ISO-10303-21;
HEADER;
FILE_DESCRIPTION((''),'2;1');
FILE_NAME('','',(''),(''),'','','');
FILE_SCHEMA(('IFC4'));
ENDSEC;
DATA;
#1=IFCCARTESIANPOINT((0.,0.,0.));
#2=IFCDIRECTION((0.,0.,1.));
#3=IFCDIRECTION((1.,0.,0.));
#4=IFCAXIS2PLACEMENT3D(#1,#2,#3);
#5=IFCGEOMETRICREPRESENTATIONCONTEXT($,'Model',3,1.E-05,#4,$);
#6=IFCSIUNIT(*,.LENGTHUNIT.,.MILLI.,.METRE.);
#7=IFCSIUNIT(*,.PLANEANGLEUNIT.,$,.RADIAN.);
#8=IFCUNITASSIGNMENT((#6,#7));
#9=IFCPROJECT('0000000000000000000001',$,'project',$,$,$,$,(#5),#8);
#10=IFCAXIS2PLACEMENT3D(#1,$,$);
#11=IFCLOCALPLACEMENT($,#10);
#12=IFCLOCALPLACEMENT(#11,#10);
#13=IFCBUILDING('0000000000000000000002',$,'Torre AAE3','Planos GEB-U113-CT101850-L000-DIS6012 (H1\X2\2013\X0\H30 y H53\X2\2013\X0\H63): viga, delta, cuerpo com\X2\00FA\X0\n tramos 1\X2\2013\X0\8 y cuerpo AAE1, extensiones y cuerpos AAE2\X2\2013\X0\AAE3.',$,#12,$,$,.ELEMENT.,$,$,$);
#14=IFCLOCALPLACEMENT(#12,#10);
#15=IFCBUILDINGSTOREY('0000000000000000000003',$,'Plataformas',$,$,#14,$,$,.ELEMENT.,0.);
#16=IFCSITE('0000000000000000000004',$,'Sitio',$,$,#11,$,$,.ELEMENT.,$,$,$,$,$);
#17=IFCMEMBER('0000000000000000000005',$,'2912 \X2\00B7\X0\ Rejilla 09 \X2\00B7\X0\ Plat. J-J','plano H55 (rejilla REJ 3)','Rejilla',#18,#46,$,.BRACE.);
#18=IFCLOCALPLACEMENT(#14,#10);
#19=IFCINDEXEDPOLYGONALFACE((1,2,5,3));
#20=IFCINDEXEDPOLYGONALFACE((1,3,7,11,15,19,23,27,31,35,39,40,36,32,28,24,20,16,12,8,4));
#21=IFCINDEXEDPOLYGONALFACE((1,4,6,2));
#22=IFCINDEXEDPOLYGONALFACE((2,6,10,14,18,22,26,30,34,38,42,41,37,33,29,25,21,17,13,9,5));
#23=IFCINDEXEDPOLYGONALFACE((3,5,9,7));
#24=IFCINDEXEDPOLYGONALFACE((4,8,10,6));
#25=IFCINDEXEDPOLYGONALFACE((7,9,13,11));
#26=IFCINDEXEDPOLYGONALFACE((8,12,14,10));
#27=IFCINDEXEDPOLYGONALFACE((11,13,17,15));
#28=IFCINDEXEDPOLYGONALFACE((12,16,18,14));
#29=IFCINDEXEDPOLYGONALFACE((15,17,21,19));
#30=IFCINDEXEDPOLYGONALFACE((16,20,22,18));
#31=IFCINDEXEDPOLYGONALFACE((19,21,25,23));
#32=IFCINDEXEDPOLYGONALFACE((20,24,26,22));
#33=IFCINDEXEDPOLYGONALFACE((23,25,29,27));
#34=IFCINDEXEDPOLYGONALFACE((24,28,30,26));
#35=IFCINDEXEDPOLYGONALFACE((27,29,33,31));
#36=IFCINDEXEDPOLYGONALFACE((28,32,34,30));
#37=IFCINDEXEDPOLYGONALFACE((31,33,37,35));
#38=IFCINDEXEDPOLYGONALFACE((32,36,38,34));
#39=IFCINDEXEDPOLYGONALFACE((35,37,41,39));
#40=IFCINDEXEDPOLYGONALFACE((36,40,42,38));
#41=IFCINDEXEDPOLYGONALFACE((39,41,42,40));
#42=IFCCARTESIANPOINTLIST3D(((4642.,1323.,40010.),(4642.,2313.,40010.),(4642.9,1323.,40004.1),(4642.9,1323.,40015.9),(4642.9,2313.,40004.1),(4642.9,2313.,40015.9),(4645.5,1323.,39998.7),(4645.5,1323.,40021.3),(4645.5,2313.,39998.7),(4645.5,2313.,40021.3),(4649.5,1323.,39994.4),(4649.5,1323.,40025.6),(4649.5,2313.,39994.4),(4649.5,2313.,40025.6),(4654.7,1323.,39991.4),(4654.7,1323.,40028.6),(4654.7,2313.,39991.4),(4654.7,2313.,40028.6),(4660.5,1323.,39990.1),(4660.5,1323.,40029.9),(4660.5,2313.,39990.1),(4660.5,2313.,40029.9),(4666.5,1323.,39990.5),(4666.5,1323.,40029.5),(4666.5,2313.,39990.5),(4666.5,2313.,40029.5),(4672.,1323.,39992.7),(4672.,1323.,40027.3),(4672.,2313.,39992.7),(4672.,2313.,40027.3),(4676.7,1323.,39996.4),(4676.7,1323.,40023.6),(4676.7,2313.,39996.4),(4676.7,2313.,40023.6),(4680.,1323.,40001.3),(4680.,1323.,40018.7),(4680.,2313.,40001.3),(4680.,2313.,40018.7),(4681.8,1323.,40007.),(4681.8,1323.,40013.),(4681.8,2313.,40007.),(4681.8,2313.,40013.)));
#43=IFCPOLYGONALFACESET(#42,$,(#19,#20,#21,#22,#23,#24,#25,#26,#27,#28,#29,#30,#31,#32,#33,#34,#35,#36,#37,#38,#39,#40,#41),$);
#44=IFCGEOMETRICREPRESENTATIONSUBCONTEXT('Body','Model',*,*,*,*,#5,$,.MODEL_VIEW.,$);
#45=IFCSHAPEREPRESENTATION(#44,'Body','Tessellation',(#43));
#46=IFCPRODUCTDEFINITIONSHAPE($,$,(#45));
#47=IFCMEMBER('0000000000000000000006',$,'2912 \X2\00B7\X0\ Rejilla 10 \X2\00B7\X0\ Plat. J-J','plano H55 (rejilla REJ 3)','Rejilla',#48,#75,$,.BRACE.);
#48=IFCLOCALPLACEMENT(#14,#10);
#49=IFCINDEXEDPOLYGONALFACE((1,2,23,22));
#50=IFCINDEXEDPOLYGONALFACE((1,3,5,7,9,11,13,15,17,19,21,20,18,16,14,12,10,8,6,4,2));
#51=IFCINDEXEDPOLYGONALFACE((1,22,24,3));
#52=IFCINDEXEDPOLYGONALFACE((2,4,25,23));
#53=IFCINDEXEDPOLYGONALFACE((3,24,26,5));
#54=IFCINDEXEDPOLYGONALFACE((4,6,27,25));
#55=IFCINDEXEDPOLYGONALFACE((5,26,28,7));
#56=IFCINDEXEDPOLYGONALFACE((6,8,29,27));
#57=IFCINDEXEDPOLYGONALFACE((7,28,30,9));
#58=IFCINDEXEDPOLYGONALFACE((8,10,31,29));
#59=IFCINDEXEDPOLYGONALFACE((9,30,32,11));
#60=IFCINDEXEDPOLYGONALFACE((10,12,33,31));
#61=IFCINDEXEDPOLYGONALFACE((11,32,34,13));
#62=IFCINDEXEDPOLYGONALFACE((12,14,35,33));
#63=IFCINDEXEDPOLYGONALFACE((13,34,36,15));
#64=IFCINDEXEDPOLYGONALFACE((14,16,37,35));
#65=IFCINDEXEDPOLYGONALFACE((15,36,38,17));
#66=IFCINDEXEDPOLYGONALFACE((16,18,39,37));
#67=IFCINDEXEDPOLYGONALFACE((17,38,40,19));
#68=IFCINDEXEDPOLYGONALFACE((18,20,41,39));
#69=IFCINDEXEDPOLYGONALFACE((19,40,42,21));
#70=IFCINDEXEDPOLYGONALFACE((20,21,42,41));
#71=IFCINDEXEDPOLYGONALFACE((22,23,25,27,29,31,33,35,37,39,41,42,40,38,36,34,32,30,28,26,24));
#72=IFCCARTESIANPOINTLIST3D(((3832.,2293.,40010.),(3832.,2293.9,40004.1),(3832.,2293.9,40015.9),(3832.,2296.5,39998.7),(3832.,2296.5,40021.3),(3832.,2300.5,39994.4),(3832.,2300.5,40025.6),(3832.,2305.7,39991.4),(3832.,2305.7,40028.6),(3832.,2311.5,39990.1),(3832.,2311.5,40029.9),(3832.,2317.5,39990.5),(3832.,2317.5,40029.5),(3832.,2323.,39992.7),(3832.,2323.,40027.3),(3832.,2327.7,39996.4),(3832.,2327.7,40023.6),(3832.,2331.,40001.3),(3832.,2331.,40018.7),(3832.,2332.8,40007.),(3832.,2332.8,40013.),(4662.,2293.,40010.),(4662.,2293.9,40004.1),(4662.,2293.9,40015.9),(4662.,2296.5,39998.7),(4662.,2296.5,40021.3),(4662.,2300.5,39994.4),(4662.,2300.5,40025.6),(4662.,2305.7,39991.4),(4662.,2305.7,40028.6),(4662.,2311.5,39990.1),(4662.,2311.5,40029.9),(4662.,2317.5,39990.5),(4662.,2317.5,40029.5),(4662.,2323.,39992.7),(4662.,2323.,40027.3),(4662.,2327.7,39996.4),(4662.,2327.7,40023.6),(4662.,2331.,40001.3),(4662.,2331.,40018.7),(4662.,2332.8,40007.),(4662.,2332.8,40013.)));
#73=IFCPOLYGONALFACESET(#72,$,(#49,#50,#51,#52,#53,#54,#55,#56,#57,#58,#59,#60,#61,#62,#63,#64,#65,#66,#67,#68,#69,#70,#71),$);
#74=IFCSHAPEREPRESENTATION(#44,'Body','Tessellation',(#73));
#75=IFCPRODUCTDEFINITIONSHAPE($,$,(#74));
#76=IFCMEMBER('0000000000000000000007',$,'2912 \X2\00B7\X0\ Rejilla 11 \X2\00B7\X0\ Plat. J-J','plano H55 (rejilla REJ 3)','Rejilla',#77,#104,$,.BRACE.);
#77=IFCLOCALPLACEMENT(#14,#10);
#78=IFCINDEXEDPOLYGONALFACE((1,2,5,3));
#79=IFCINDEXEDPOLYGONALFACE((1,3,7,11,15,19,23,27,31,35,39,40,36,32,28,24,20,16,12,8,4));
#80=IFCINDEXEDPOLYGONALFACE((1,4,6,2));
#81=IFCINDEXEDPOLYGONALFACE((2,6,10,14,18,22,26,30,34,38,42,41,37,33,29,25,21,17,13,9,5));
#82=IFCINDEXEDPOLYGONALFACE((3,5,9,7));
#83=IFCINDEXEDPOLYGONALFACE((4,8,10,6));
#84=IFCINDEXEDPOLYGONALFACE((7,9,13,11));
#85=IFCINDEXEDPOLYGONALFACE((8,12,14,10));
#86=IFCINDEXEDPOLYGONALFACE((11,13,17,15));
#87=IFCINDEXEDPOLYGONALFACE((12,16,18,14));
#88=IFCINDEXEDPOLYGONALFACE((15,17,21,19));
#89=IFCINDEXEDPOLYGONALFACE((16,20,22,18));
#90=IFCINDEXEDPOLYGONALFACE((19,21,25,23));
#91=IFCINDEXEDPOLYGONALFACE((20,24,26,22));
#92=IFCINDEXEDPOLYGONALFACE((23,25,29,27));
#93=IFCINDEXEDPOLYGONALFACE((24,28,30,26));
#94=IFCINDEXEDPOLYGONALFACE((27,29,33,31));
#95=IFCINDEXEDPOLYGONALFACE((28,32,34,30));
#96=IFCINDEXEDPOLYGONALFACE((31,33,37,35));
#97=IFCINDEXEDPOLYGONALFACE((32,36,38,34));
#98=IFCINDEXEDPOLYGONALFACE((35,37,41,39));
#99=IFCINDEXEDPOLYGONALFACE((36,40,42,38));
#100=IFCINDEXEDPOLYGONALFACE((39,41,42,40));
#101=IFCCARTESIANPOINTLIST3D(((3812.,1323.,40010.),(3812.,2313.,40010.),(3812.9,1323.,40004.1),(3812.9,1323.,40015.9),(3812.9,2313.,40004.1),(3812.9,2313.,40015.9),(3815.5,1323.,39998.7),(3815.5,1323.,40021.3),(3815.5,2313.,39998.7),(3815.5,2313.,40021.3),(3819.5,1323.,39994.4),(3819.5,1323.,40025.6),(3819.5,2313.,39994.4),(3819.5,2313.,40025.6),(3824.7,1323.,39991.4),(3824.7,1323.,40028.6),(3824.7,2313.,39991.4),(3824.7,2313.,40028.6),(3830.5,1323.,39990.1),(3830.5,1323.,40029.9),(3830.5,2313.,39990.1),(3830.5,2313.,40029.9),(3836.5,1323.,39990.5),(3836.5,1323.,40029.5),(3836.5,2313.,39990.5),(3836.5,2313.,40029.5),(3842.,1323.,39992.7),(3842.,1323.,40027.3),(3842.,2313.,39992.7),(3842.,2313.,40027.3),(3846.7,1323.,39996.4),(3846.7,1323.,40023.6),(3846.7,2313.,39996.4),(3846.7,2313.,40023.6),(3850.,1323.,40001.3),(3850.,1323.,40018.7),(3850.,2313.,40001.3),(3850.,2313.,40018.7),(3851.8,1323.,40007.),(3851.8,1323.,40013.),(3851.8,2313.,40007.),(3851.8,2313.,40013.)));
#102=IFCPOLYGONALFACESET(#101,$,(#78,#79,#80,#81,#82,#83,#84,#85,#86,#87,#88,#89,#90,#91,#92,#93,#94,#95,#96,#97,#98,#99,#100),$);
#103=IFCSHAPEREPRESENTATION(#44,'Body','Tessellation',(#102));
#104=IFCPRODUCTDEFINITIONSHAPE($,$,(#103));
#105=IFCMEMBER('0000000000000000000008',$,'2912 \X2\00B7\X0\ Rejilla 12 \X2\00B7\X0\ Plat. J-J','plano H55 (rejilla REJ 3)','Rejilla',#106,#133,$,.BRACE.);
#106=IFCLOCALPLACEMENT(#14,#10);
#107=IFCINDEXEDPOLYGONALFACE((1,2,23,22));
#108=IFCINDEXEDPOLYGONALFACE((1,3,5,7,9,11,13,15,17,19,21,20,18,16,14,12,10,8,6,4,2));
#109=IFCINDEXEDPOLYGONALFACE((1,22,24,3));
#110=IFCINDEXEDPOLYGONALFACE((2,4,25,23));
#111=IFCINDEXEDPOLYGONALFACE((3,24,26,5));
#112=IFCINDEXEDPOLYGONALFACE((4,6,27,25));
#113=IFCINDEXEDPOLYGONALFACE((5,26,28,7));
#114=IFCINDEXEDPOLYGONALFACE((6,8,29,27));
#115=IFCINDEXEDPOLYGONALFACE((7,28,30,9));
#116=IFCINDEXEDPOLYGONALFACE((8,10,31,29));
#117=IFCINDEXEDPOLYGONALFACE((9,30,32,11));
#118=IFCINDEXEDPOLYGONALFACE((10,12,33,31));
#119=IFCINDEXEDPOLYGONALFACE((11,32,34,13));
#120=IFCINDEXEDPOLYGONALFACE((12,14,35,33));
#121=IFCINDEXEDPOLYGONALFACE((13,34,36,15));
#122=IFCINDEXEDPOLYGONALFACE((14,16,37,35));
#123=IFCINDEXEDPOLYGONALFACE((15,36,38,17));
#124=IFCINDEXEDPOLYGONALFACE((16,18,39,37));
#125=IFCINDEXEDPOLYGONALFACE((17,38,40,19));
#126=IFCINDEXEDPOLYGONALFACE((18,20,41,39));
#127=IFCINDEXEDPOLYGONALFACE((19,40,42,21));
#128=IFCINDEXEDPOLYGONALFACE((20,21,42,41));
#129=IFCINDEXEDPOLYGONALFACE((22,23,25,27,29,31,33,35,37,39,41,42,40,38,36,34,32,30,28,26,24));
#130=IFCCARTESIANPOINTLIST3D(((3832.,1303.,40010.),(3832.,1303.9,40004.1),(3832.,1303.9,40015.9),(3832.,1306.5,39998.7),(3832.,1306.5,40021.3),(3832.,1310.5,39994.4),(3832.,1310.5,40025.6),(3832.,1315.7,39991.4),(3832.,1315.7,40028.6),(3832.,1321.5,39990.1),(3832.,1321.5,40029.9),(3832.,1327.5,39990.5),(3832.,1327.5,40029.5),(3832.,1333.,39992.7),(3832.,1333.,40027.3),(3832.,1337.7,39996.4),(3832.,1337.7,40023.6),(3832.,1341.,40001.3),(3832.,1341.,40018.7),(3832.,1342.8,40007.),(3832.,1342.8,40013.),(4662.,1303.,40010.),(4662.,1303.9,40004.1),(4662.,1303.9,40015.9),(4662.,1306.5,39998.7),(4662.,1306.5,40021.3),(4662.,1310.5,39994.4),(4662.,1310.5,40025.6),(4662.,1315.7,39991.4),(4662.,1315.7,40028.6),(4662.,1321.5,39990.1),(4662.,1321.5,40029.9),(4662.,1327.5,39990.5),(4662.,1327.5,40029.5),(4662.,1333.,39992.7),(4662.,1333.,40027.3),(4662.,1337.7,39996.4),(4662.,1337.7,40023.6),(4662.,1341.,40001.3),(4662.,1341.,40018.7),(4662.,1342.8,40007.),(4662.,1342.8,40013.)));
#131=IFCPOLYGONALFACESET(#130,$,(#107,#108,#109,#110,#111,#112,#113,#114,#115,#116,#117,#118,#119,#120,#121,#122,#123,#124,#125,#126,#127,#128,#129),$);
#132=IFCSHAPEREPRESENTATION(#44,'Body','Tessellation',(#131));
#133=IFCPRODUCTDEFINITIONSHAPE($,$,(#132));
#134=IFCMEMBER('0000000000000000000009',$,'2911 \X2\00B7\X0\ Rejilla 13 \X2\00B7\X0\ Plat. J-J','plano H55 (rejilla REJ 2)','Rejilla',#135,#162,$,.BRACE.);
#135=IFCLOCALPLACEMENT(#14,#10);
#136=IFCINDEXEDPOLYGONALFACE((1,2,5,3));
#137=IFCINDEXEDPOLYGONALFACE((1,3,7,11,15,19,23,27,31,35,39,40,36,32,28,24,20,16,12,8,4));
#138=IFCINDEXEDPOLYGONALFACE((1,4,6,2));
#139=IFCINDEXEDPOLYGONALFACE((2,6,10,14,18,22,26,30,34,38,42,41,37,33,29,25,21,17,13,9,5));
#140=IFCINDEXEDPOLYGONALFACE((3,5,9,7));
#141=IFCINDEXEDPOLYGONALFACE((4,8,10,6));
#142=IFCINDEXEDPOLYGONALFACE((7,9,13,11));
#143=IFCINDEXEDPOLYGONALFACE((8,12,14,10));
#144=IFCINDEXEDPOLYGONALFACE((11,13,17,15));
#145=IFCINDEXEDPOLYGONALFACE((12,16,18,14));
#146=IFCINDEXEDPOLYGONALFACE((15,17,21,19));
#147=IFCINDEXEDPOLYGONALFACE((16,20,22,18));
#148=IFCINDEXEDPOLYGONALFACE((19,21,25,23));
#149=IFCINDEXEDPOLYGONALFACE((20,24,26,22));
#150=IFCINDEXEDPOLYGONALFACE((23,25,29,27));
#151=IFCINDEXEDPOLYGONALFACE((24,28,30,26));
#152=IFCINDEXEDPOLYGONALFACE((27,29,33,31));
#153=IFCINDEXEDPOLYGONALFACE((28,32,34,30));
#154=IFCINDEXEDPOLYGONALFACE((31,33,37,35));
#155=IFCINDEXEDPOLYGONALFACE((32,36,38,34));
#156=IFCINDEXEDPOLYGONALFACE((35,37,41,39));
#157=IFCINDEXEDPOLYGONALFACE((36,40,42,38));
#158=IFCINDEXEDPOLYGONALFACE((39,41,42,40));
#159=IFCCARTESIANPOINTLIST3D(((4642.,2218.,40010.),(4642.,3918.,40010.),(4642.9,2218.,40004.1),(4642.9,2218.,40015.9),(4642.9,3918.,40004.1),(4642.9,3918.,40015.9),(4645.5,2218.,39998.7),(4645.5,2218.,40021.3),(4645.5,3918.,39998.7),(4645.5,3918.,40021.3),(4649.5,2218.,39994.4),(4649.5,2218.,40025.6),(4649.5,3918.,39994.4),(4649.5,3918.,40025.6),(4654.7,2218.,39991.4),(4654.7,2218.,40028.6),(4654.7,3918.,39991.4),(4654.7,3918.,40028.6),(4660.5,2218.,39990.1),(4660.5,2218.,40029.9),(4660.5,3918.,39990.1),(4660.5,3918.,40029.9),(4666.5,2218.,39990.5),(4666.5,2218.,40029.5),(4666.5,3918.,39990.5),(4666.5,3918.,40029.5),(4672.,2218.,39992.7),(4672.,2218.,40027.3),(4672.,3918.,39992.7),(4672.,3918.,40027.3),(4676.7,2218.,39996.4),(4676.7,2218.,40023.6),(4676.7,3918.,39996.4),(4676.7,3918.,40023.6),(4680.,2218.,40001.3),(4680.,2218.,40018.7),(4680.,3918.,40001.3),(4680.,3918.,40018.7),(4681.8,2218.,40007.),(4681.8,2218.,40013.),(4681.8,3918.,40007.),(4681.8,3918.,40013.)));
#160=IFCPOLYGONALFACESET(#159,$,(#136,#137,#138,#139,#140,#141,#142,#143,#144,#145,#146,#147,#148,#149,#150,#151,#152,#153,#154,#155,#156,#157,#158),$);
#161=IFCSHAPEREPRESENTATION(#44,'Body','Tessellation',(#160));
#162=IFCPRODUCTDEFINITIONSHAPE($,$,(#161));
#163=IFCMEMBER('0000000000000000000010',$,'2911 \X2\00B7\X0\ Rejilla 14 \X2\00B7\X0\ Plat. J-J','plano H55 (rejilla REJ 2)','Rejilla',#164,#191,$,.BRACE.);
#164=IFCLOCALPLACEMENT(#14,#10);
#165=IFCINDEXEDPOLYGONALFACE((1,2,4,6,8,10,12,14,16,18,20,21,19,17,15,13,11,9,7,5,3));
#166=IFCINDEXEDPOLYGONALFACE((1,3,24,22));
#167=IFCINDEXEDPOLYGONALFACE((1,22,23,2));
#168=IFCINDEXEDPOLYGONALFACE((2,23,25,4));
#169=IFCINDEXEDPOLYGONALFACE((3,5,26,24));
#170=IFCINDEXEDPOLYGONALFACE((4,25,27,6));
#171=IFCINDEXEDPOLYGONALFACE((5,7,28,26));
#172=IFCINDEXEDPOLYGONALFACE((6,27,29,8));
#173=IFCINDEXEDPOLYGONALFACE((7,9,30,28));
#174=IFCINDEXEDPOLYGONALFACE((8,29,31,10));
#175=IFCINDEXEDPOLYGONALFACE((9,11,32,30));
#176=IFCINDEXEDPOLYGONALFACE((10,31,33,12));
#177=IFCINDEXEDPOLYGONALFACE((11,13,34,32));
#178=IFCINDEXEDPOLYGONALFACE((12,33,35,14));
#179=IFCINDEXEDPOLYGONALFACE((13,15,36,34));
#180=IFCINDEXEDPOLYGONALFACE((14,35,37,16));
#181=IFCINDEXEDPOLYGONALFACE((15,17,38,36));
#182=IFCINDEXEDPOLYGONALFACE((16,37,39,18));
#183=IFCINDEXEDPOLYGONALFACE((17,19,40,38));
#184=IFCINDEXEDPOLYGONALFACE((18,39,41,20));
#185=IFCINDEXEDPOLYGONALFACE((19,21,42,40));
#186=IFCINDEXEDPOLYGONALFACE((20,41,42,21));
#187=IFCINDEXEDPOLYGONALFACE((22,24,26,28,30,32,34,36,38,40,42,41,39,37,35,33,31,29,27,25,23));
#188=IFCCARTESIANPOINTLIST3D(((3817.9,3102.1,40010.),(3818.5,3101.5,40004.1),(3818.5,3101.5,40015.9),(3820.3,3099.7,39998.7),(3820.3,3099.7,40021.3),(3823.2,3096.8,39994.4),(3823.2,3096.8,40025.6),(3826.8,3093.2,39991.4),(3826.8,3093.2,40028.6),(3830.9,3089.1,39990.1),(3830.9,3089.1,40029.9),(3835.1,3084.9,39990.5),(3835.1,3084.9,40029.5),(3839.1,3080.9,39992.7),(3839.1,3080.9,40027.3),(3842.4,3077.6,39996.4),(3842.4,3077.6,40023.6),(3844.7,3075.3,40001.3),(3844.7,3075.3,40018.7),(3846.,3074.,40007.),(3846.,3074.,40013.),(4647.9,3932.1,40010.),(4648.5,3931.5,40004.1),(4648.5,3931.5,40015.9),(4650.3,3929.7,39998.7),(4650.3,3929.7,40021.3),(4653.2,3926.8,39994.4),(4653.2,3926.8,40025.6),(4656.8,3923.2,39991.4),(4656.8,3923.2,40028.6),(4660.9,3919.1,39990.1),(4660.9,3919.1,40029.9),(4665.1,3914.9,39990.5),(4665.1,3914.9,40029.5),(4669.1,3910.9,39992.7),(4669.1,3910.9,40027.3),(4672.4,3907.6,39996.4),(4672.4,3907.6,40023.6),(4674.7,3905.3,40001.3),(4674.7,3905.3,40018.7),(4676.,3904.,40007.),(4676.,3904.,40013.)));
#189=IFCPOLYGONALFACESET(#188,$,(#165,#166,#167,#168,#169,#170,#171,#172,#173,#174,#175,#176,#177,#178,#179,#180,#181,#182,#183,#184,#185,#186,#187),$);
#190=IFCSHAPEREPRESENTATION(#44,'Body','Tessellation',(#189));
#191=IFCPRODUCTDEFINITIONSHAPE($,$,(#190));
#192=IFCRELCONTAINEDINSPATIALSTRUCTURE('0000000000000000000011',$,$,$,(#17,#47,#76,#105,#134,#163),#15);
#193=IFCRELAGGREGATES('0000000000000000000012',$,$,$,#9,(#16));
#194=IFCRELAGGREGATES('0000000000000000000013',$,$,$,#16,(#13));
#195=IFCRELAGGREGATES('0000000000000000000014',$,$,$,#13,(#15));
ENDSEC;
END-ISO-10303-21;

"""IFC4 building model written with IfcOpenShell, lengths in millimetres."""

from ifc_helpers import new_model, si_unit, frame, origin, origin_with_axes, place, context, subcontext, project, spatial, circle, extrude, element, save


model = new_model("IFC4")

# Units and contexts
model_context = context("Model", 3, precision=1e-05, world=origin_with_axes())
body_context = subcontext(model_context, "Body", "Model", "MODEL_VIEW")
ifc_project = project(units=[si_unit("LENGTHUNIT", "METRE", prefix="MILLI"), si_unit("PLANEANGLEUNIT", "RADIAN")], contexts=[model_context])

# Site, building, storey
site_placement = place(None, origin())
site = spatial("IfcSite", under=ifc_project, at=site_placement, Name="Sitio", CompositionType="ELEMENT")
building_placement = place(site_placement, origin())
building = spatial("IfcBuilding", under=site, at=building_placement, Name="Torre AAE3", Description="Planos GEB-U113-CT101850-L000-DIS6012 (H1–H30 y H53–H63): viga, delta, cuerpo común tramos 1–8 y cuerpo AAE1, extensiones y cuerpos AAE2–AAE3.", CompositionType="ELEMENT")
storey_placement = place(building_placement, origin())
storey = spatial("IfcBuildingStorey", under=building, at=storey_placement, Name="Plataformas", CompositionType="ELEMENT", Elevation=0.0)

# Members
member_1_placement = place(storey_placement, frame((4662.0, 1323.0, 40010.0), z_axis=(0.0, 1.0, 0.0), x_axis=(-1.0, 0.0, 0.0)))
element("IfcMember", 1, at=member_1_placement, inside=storey, Name="2912 · Rejilla 09 · Plat. J-J", Description="plano H55 (rejilla REJ 3)", ObjectType="Rejilla", PredefinedType="BRACE", context=body_context, shape_type="SweptSolid", body=[
    extrude(circle(Radius=20.0), None, (0.0, 0.0, 1.0), 990.0),
])
member_2_placement = place(storey_placement, frame((4662.0, 2313.0, 40010.0), z_axis=(-1.0, 0.0, 0.0), x_axis=(0.0, -1.0, 0.0)))
element("IfcMember", 2, at=member_2_placement, inside=storey, Name="2912 · Rejilla 10 · Plat. J-J", Description="plano H55 (rejilla REJ 3)", ObjectType="Rejilla", PredefinedType="BRACE", context=body_context, shape_type="SweptSolid", body=[
    extrude(circle(Radius=20.0), None, (0.0, 0.0, 1.0), 830.0),
])
member_3_placement = place(storey_placement, frame((3832.0, 2313.0, 40010.0), z_axis=(0.0, -1.0, 0.0), x_axis=(-1.0, 0.0, 0.0)))
element("IfcMember", 3, at=member_3_placement, inside=storey, Name="2912 · Rejilla 11 · Plat. J-J", Description="plano H55 (rejilla REJ 3)", ObjectType="Rejilla", PredefinedType="BRACE", context=body_context, shape_type="SweptSolid", body=[
    extrude(circle(Radius=20.0), None, (0.0, 0.0, 1.0), 990.0),
])
member_4_placement = place(storey_placement, frame((3832.0, 1323.0, 40010.0), z_axis=(1.0, 0.0, 0.0), x_axis=(0.0, -1.0, 0.0)))
element("IfcMember", 4, at=member_4_placement, inside=storey, Name="2912 · Rejilla 12 · Plat. J-J", Description="plano H55 (rejilla REJ 3)", ObjectType="Rejilla", PredefinedType="BRACE", context=body_context, shape_type="SweptSolid", body=[
    extrude(circle(Radius=20.0), None, (0.0, 0.0, 1.0), 830.0),
])
member_5_placement = place(storey_placement, frame((4662.0, 2218.0, 40010.0), z_axis=(0.0, 1.0, 0.0), x_axis=(-1.0, 0.0, 0.0)))
element("IfcMember", 5, at=member_5_placement, inside=storey, Name="2911 · Rejilla 13 · Plat. J-J", Description="plano H55 (rejilla REJ 2)", ObjectType="Rejilla", PredefinedType="BRACE", context=body_context, shape_type="SweptSolid", body=[
    extrude(circle(Radius=20.0), None, (0.0, 0.0, 1.0), 1700.0),
])
member_6_placement = place(storey_placement, frame((4662.0, 3918.0, 40010.0), z_axis=(-0.707107, -0.707107, 0.0), x_axis=(-0.707107, 0.707107, 0.0)))
element("IfcMember", 6, at=member_6_placement, inside=storey, Name="2911 · Rejilla 14 · Plat. J-J", Description="plano H55 (rejilla REJ 2)", ObjectType="Rejilla", PredefinedType="BRACE", context=body_context, shape_type="SweptSolid", body=[
    extrude(circle(Radius=20.0), None, (0.0, 0.0, 1.0), 1173.8),
])

save(model, "model.ifc")
